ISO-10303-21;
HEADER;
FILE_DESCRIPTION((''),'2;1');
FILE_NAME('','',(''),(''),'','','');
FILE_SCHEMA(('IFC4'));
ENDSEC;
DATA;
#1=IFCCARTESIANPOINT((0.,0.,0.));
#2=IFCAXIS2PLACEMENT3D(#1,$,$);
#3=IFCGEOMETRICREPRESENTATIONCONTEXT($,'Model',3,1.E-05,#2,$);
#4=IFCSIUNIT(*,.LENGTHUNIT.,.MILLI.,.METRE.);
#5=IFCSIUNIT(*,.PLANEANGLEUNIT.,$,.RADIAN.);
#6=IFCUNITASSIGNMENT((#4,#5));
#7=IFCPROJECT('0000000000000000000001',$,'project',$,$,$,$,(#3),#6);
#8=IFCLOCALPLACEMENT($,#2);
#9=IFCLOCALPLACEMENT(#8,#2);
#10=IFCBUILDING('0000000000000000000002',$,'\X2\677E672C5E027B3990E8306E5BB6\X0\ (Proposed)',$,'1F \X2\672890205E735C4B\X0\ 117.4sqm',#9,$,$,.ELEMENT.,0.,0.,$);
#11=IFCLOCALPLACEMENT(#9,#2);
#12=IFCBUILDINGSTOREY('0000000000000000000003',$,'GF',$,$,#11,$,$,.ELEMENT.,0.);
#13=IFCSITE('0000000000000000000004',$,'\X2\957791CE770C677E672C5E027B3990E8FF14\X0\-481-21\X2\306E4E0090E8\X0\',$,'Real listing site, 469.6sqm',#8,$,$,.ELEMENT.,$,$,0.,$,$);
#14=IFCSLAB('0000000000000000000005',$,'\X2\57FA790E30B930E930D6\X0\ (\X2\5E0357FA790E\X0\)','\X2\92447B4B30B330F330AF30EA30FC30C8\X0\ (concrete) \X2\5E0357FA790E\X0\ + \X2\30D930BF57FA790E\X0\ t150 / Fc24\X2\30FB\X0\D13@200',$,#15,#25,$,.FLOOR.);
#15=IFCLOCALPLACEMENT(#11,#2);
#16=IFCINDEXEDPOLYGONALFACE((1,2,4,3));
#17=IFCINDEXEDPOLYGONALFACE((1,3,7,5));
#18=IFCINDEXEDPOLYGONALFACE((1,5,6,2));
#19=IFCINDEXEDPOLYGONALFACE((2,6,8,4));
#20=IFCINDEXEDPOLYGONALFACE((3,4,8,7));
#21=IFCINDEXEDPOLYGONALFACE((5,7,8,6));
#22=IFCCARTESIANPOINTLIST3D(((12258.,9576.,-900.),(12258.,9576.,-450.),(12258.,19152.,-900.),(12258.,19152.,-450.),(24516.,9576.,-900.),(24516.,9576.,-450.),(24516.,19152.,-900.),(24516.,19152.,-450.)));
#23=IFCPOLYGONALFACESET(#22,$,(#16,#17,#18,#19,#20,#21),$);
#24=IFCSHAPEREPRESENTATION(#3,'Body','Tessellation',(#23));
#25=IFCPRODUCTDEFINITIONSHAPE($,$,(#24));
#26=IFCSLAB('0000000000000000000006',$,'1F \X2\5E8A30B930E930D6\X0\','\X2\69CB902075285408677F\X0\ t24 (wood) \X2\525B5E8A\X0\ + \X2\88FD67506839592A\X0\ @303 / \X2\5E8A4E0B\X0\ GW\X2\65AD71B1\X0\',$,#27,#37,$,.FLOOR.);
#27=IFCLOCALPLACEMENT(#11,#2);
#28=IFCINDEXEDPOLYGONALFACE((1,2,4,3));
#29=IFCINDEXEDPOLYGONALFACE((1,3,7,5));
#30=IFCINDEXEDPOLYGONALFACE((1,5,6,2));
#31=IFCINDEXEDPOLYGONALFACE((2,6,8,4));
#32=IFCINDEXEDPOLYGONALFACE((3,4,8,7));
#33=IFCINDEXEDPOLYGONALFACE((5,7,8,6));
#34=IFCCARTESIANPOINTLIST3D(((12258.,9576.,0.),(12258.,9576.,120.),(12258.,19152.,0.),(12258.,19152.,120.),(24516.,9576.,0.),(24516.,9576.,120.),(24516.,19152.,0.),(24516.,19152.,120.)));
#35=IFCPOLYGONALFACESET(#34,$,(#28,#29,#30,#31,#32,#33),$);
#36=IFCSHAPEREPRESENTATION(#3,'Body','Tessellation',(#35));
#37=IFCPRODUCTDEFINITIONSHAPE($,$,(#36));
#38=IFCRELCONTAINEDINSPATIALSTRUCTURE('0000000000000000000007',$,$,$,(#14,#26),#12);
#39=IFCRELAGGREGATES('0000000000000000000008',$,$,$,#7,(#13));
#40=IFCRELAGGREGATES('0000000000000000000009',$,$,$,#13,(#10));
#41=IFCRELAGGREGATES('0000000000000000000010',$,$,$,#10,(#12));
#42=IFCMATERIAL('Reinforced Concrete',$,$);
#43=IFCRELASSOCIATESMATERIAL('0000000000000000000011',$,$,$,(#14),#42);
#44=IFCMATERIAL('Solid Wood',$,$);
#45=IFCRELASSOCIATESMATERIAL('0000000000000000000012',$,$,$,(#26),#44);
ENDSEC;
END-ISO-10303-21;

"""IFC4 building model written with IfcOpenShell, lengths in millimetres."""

from ifc_helpers import new_model, si_unit, frame, frame_2d, origin, place, context, project, spatial, rectangle, extrude, material, element, save


model = new_model("IFC4")

# Units and contexts
model_context = context("Model", 3, precision=1e-05, world=origin())
ifc_project = project(units=[si_unit("LENGTHUNIT", "METRE", prefix="MILLI"), si_unit("PLANEANGLEUNIT", "RADIAN")], contexts=[model_context])

# Site, building, storey
site_placement = place(None, origin())
site = spatial("IfcSite", under=ifc_project, at=site_placement, Name="長野県松本市笹部４-481-21の一部", ObjectType="Real listing site, 469.6sqm", CompositionType="ELEMENT", RefElevation=0.0)
building_placement = place(site_placement, origin())
building = spatial("IfcBuilding", under=site, at=building_placement, Name="松本市笹部の家 (Proposed)", ObjectType="1F 木造平屋 117.4sqm", CompositionType="ELEMENT", ElevationOfRefHeight=0.0, ElevationOfTerrain=0.0)
storey_placement = place(building_placement, origin())
storey = spatial("IfcBuildingStorey", under=building, at=storey_placement, Name="GF", CompositionType="ELEMENT", Elevation=0.0)

# Slabs
ifc_material_1 = material(Name="Reinforced Concrete")
slab_1_placement = place(storey_placement, frame((6129.0, 4788.0, -450.0)))
element("IfcSlab", 1, at=slab_1_placement, inside=storey, material=ifc_material_1, Name="基礎スラブ (布基礎)", Description="鉄筋コンクリート (concrete) 布基礎 + ベタ基礎 t150 / Fc24・D13@200", PredefinedType="FLOOR", context=model_context, shape_type="SweptSolid", body=[
    extrude(rectangle(XDim=12258.0, YDim=9576.0, at=frame_2d((6129.0, 4788.0))), frame((6129.0, 4788.0, -450.0)), (0.0, 0.0, 1.0), 450.0),
])
ifc_material_2 = material(Name="Solid Wood")
slab_2_placement = place(storey_placement, frame((6129.0, 4788.0, 0.0)))
element("IfcSlab", 2, at=slab_2_placement, inside=storey, material=ifc_material_2, Name="1F 床スラブ", Description="構造用合板 t24 (wood) 剛床 + 製材根太 @303 / 床下 GW断熱", PredefinedType="FLOOR", context=model_context, shape_type="SweptSolid", body=[
    extrude(rectangle(XDim=12258.0, YDim=9576.0, at=frame_2d((6129.0, 4788.0))), frame((6129.0, 4788.0, 0.0)), (0.0, 0.0, 1.0), 120.0),
])

save(model, "model.ifc")
